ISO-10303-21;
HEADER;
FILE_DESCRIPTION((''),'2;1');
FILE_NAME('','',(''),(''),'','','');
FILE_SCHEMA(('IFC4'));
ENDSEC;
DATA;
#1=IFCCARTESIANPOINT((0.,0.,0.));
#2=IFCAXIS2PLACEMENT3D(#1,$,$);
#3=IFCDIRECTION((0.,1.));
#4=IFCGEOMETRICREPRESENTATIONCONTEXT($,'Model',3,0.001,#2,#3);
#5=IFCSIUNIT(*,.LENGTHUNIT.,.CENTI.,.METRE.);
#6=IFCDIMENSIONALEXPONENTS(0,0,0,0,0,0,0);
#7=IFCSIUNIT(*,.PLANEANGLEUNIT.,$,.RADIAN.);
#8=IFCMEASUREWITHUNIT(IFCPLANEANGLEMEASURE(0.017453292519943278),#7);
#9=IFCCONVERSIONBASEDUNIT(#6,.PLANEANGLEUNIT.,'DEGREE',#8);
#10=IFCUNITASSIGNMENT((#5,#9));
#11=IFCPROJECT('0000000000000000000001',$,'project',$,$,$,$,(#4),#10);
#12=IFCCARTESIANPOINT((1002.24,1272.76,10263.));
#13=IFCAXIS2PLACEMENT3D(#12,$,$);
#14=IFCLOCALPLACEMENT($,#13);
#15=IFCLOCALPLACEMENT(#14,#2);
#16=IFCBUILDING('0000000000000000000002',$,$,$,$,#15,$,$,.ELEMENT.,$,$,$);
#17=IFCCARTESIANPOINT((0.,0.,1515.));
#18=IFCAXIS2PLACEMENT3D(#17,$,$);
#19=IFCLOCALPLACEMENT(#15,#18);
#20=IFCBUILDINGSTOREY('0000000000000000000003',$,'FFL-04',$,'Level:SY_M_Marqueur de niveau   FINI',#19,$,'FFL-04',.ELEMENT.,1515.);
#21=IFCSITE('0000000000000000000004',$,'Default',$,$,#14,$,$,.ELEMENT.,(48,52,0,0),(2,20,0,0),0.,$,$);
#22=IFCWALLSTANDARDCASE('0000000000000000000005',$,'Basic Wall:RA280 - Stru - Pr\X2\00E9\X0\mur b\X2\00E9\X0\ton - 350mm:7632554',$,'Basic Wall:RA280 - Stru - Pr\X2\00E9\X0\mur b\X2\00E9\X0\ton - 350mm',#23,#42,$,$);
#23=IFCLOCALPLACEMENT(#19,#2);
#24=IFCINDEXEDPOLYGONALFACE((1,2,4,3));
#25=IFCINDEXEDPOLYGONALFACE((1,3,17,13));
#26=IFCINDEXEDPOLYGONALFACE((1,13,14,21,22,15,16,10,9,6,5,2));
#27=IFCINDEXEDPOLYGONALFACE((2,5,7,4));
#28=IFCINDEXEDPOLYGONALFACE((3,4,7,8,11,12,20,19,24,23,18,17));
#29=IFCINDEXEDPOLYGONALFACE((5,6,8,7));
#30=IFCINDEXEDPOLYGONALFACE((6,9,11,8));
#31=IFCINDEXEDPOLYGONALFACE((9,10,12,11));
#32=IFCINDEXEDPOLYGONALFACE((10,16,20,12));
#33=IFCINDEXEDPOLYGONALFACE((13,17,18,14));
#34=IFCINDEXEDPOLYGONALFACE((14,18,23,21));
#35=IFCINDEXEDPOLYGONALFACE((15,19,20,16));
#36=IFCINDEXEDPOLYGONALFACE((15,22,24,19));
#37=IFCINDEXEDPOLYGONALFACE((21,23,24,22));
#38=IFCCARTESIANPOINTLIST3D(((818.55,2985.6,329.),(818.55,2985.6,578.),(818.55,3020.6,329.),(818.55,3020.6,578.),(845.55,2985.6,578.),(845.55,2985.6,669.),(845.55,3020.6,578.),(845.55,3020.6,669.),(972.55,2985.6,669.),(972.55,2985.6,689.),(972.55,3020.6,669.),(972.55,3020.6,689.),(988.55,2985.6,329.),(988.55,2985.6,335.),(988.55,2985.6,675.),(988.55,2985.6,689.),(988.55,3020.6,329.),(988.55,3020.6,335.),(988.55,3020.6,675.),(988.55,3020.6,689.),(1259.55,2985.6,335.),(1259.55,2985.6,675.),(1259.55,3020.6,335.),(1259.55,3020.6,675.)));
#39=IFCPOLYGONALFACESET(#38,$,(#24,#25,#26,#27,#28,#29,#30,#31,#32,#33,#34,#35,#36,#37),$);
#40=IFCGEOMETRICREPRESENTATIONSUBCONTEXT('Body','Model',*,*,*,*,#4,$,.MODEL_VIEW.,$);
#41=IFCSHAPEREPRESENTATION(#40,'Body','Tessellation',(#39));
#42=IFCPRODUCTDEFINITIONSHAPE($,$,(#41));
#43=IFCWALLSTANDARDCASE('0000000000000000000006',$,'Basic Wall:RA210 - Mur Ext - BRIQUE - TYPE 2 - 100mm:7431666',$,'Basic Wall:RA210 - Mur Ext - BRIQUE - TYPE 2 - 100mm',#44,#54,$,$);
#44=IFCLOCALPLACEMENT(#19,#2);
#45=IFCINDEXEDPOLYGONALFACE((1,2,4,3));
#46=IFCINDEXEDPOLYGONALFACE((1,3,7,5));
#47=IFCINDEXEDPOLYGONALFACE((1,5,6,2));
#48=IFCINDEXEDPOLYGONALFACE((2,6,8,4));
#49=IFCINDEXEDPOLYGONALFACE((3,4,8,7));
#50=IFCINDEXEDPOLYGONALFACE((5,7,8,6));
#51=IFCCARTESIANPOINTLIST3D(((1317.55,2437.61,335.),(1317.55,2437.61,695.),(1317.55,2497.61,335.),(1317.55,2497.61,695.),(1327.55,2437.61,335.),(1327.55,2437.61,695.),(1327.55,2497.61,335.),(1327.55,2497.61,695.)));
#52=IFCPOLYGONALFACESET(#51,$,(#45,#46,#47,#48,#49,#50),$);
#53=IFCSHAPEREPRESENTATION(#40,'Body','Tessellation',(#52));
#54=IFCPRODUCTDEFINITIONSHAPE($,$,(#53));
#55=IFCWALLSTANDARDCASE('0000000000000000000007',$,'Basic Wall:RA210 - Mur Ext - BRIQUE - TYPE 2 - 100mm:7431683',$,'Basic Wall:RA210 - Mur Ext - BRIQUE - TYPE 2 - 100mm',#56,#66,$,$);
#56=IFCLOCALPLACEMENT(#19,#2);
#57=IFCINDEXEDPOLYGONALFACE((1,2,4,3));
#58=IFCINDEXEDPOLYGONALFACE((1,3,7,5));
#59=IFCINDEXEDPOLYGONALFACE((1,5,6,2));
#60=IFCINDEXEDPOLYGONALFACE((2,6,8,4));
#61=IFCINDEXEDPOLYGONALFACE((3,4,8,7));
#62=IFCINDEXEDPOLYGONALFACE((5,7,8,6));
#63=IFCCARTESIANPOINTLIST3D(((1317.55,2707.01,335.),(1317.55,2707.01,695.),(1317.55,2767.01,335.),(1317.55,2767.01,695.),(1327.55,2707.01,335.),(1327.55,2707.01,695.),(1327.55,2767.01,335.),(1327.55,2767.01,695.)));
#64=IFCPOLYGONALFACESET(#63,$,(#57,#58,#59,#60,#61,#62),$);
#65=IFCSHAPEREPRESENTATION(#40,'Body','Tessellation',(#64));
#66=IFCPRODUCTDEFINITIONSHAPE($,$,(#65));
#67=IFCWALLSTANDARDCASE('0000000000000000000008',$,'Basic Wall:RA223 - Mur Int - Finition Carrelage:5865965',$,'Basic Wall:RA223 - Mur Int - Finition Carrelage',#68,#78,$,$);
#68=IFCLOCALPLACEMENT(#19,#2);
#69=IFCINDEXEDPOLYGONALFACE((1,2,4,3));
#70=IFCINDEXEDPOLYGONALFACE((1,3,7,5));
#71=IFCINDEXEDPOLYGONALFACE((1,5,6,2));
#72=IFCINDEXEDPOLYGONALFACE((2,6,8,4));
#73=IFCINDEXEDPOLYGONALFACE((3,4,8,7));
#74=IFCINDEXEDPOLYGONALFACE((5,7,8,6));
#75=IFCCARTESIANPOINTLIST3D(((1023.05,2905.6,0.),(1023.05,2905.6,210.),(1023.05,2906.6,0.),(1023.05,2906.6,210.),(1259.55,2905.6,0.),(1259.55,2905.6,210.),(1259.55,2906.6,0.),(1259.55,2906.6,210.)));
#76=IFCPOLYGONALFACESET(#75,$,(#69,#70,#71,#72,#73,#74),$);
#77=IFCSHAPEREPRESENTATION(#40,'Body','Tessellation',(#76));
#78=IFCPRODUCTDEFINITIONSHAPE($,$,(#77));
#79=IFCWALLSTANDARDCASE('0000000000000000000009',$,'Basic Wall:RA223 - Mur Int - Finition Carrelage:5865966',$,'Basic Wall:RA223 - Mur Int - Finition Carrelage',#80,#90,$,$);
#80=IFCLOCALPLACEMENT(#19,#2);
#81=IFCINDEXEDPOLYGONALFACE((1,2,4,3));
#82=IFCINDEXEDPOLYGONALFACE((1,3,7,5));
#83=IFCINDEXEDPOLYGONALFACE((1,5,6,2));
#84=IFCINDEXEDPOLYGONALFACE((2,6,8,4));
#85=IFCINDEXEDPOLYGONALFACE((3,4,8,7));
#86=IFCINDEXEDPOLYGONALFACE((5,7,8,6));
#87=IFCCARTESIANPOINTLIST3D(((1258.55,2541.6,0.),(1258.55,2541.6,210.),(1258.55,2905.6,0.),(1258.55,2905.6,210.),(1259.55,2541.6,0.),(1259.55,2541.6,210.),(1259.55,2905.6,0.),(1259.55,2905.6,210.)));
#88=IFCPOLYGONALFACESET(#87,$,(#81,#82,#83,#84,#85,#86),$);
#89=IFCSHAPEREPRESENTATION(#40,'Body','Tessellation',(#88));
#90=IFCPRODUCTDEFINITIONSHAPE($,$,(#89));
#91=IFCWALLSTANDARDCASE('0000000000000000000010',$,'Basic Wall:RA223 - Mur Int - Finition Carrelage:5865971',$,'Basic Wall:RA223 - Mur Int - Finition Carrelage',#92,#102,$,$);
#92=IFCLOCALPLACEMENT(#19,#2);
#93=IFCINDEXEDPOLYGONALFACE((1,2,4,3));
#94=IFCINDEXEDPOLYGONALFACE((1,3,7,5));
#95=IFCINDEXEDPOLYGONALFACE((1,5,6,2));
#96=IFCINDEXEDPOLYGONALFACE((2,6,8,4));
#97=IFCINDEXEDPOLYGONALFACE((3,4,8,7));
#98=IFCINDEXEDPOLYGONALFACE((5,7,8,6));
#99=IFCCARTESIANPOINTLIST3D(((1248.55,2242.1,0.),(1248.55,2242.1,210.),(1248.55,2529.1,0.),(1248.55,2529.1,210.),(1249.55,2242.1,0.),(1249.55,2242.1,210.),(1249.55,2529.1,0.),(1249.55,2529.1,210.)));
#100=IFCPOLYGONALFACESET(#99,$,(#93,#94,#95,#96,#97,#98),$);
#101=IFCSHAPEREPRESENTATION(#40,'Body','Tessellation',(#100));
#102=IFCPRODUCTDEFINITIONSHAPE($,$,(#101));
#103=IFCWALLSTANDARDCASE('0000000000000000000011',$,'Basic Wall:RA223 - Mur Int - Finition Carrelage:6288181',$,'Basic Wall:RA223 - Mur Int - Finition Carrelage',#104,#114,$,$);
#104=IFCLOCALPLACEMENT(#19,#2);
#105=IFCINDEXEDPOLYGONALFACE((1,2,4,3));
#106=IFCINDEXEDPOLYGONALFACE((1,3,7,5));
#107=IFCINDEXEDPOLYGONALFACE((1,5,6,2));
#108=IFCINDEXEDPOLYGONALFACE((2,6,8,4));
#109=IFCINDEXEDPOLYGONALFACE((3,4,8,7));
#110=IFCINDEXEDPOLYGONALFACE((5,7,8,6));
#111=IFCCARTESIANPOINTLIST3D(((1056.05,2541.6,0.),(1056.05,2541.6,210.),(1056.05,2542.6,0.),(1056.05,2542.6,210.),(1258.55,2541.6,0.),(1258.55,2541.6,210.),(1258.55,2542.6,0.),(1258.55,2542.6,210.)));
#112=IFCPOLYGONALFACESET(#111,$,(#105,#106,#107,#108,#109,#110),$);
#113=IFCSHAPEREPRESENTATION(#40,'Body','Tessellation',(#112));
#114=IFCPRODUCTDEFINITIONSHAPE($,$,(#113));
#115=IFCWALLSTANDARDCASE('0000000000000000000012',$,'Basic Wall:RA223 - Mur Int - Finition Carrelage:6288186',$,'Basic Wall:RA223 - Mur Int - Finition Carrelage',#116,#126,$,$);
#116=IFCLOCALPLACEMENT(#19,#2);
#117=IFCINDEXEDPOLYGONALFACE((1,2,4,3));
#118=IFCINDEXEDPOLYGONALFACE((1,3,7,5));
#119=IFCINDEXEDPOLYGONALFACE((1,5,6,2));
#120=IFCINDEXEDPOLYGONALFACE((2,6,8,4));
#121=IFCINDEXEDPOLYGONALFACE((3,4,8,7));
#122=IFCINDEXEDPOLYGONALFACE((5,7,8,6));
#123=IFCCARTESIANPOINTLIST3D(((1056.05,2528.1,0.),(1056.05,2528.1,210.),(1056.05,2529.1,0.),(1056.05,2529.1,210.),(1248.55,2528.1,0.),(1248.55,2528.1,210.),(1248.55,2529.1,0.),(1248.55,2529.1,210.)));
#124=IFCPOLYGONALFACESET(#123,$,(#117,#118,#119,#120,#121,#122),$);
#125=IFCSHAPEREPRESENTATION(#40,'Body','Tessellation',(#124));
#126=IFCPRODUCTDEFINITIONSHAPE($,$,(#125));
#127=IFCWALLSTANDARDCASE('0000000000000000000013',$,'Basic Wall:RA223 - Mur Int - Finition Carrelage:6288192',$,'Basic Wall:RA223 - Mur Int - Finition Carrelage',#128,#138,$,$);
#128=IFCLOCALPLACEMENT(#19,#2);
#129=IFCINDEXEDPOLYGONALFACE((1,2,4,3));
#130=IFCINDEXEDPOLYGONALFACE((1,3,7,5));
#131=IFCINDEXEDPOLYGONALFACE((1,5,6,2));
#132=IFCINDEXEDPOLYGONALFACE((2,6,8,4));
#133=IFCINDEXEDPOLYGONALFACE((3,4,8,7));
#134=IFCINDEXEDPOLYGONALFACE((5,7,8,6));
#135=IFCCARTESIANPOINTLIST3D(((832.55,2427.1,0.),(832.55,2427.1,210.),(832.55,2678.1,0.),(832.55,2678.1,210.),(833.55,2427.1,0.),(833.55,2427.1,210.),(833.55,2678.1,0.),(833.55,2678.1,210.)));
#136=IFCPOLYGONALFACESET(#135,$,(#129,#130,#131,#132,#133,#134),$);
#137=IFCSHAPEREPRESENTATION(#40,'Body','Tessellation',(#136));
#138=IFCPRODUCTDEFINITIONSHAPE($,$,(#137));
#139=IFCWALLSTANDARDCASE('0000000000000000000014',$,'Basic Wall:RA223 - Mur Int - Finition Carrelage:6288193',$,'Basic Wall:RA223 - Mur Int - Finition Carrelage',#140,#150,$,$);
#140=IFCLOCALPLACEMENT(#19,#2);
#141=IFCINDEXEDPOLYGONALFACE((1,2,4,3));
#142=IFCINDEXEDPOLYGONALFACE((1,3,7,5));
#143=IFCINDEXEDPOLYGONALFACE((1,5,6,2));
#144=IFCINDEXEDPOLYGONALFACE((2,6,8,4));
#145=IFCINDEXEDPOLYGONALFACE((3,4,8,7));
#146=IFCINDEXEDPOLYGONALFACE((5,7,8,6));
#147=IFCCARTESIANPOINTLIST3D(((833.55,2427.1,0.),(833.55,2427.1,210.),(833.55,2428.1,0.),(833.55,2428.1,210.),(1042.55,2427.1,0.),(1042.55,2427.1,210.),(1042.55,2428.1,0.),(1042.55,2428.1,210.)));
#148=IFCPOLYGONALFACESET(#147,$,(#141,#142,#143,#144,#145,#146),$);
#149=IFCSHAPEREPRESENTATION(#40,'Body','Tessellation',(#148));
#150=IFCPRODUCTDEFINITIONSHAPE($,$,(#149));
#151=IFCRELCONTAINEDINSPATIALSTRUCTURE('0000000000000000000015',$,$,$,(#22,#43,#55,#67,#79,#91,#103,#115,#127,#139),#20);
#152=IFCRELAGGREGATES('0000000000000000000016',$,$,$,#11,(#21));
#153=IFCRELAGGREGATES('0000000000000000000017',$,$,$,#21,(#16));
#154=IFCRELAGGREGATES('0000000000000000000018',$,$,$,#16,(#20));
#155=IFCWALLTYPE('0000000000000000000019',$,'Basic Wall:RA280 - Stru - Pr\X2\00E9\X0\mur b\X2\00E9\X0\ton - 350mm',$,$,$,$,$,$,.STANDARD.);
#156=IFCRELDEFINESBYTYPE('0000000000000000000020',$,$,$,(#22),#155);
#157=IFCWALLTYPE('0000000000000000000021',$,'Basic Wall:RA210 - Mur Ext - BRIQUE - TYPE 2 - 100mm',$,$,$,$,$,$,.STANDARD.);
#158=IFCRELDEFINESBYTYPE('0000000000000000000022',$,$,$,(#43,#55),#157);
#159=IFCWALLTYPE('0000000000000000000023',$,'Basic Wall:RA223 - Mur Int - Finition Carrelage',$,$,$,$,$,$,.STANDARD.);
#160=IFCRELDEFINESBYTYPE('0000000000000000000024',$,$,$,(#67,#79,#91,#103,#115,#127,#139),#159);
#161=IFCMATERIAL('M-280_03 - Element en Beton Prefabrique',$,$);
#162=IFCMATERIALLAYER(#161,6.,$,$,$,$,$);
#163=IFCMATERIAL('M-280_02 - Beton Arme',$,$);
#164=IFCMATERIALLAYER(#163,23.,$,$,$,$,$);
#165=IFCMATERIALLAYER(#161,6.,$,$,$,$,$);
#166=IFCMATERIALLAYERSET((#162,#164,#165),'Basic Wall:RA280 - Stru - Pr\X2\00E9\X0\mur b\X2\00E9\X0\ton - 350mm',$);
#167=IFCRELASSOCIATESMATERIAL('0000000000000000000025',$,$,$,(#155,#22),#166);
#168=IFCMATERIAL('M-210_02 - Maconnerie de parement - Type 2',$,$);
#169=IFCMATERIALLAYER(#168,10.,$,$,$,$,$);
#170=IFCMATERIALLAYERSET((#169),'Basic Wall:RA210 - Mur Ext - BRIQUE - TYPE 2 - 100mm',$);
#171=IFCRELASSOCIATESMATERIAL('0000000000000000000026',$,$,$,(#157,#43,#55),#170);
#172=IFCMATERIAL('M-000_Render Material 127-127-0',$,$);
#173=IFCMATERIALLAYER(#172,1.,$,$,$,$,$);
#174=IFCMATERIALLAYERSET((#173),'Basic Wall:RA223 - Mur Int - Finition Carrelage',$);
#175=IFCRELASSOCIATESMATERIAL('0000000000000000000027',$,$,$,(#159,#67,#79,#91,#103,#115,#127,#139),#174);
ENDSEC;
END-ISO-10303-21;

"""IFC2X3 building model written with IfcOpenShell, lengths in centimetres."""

from ifc_helpers import new_model, entity, si_unit, converted_unit, direction, frame, frame_2d, origin, place, context, subcontext, project, spatial, polyline, rectangle, extrude, clip, bounded_halfspace, material, layer, layer_set, layer_usage, type_object, element, save


model = new_model("IFC2X3")

# Units and contexts
model_context = context("Model", 3, precision=0.001, world=origin(), true_north=direction((0.0, 1.0)))
body_context = subcontext(model_context, "Body", "Model", "MODEL_VIEW")
ifc_project = project(units=[si_unit("LENGTHUNIT", "METRE", prefix="CENTI"), converted_unit("PLANEANGLEUNIT", "DEGREE", entity("IfcPlaneAngleMeasure", 0.017453292519943278), si_unit("PLANEANGLEUNIT", "RADIAN"), dimensions=[0, 0, 0, 0, 0, 0, 0])], contexts=[model_context])

# Site, building, storey
site_placement = place(None, frame((1002.24, 1272.76, 10263.0)))
site = spatial("IfcSite", under=ifc_project, at=site_placement, Name="Default", CompositionType="ELEMENT", RefLatitude=(48, 52, 0, 0), RefLongitude=(2, 20, 0, 0), RefElevation=0.0)
building_placement = place(site_placement, origin())
building = spatial("IfcBuilding", under=site, at=building_placement, CompositionType="ELEMENT")
storey_placement = place(building_placement, frame((0.0, 0.0, 1515.0)))
storey = spatial("IfcBuildingStorey", under=building, at=storey_placement, Name="FFL-04", ObjectType="Level:SY_M_Marqueur de niveau   FINI", LongName="FFL-04", CompositionType="ELEMENT", Elevation=1515.0)

# Shared definitions
ifc_material_1 = material(Name="M-280_02 - Beton Arme")

# Walls
ifc_material_2 = material(Name="M-210_02 - Maconnerie de parement - Type 2")
ifc_material_3 = material(Name="M-280_03 - Element en Beton Prefabrique")
ifc_layer_1 = layer(ifc_material_3, 6.0)
ifc_layer_2 = layer(ifc_material_1, 23.0)
ifc_layer_3 = layer(ifc_material_3, 6.0)
ifc_layer_set_1 = layer_set([ifc_layer_1, ifc_layer_2, ifc_layer_3], Name="Basic Wall:RA280 - Stru - Prémur béton - 350mm")
ifc_layer_usage_1 = layer_usage(ifc_layer_set_1, "AXIS2", "NEGATIVE", 17.5)
wall_type_1 = type_object("IfcWallType", Name="Basic Wall:RA280 - Stru - Prémur béton - 350mm", PredefinedType="STANDARD", material=ifc_layer_set_1)
wall_1_placement = place(storey_placement, frame((818.55, 3003.1, 329.0)))
element("IfcWallStandardCase", 1, at=wall_1_placement, inside=storey, type_object=wall_type_1, material=ifc_layer_usage_1, Name="Basic Wall:RA280 - Stru - Prémur béton - 350mm:7632554", ObjectType="Basic Wall:RA280 - Stru - Prémur béton - 350mm", context=body_context, shape_type="Clipping", body=[
    clip(clip(clip(clip(clip(clip(clip(clip(extrude(rectangle(XDim=440.99, YDim=35.0, at=frame_2d((220.5, 0.0), x_axis=(-1.0, 0.0))), origin(), (0.0, 0.0, 1.0), 360.0), bounded_halfspace(frame((27.0, -17.5, 340.0), z_axis=(1.0, 0.0, 0.0), x_axis=(0.0, 0.0, 1.0)), True, frame((27.0, -17.5, 340.0), z_axis=(1.0, 0.0, 0.0), x_axis=(0.0, 0.0, 1.0)), polyline([(0.0, 0.0), (-6.0, 0.0), (-91.0, 0.0), (-91.0, -35.0), (0.0, -35.0), (0.0, 0.0)]))), bounded_halfspace(frame((169.99, 17.5, 346.0), z_axis=(0.0, 0.0, -1.0), x_axis=(-1.0, 0.0, 0.0)), True, frame((169.99, 17.5, 346.0), z_axis=(0.0, 0.0, -1.0), x_axis=(-1.0, 0.0, 0.0)), polyline([(0.0, 0.0), (-271.0, 0.0), (-271.0, -35.0), (-256.25, -35.0), (-250.0, -35.0), (-66.51, -35.0), (-54.01, -35.0), (-25.0, -35.0), (0.0, -35.0), (0.0, 0.0)]))), bounded_halfspace(frame((169.99, -17.5, 346.0), z_axis=(-1.0, 0.0, 0.0), x_axis=(0.0, 0.0, 1.0)), True, frame((169.99, -17.5, 346.0), z_axis=(-1.0, 0.0, 0.0), x_axis=(0.0, 0.0, 1.0)), polyline([(0.0, 0.0), (14.0, 0.0), (14.0, 35.0), (0.0, 35.0), (0.0, 0.0)]))), bounded_halfspace(frame((153.99, -17.5, 340.0), z_axis=(0.0, 0.0, -1.0), x_axis=(1.0, 0.0, 0.0)), True, frame((153.99, -17.5, 340.0), z_axis=(0.0, 0.0, -1.0), x_axis=(1.0, 0.0, 0.0)), polyline([(0.0, 0.0), (-126.99, 0.0), (-126.99, -35.0), (0.0, -35.0), (0.0, 0.0)]))), bounded_halfspace(frame((153.99, 17.5, 340.0), z_axis=(1.0, 0.0, 0.0), x_axis=(0.0, 0.0, 1.0)), True, frame((153.99, 17.5, 340.0), z_axis=(1.0, 0.0, 0.0), x_axis=(0.0, 0.0, 1.0)), polyline([(0.0, 0.0), (20.0, 0.0), (20.0, 35.0), (0.0, 35.0), (0.0, 0.0)]))), bounded_halfspace(frame((169.99, -17.5, 6.0)), True, frame((169.99, -17.5, 6.0)), polyline([(0.0, 0.0), (271.0, 0.0), (271.0, 35.0), (0.0, 35.0), (0.0, 0.0)]))), bounded_halfspace(frame((169.99, 17.5, 6.0), z_axis=(-1.0, 0.0, 0.0), x_axis=(0.0, 0.0, 1.0)), True, frame((169.99, 17.5, 6.0), z_axis=(-1.0, 0.0, 0.0), x_axis=(0.0, 0.0, 1.0)), polyline([(0.0, 0.0), (-6.0, 0.0), (-6.0, -35.0), (0.0, -35.0), (0.0, 0.0)]))), bounded_halfspace(frame((27.0, -17.5, 249.0)), False, frame((27.0, -17.5, 249.0)), polyline([(0.0, 0.0), (0.0, 35.0), (-27.0, 35.0), (-27.0, 0.0), (0.0, 0.0)]))),
])
ifc_layer_4 = layer(ifc_material_2, 10.0)
ifc_layer_set_2 = layer_set([ifc_layer_4], Name="Basic Wall:RA210 - Mur Ext - BRIQUE - TYPE 2 - 100mm")
ifc_layer_usage_2 = layer_usage(ifc_layer_set_2, "AXIS2", "POSITIVE", -5.0)
wall_type_2 = type_object("IfcWallType", Name="Basic Wall:RA210 - Mur Ext - BRIQUE - TYPE 2 - 100mm", PredefinedType="STANDARD", material=ifc_layer_set_2)
wall_2_placement = place(storey_placement, frame((1322.55, 2437.61, 335.0), z_axis=(0.0, 0.0, 1.0), x_axis=(0.0, 1.0, 0.0)))
element("IfcWallStandardCase", 2, at=wall_2_placement, inside=storey, type_object=wall_type_2, material=ifc_layer_usage_2, Name="Basic Wall:RA210 - Mur Ext - BRIQUE - TYPE 2 - 100mm:7431666", ObjectType="Basic Wall:RA210 - Mur Ext - BRIQUE - TYPE 2 - 100mm", context=body_context, shape_type="SweptSolid", body=[
    extrude(rectangle(XDim=60.0, YDim=10.0, at=frame_2d((30.0, 0.0), x_axis=(-1.0, 0.0))), origin(), (0.0, 0.0, 1.0), 360.0),
])
ifc_layer_usage_3 = layer_usage(ifc_layer_set_2, "AXIS2", "POSITIVE", -5.0)
wall_3_placement = place(storey_placement, frame((1322.55, 2707.01, 335.0), z_axis=(0.0, 0.0, 1.0), x_axis=(0.0, 1.0, 0.0)))
element("IfcWallStandardCase", 3, at=wall_3_placement, inside=storey, type_object=wall_type_2, material=ifc_layer_usage_3, Name="Basic Wall:RA210 - Mur Ext - BRIQUE - TYPE 2 - 100mm:7431683", ObjectType="Basic Wall:RA210 - Mur Ext - BRIQUE - TYPE 2 - 100mm", context=body_context, shape_type="SweptSolid", body=[
    extrude(rectangle(XDim=60.0, YDim=10.0, at=frame_2d((30.0, 0.0), x_axis=(-1.0, 0.0))), origin(), (0.0, 0.0, 1.0), 360.0),
])
ifc_material_4 = material(Name="M-000_Render Material 127-127-0")
ifc_layer_5 = layer(ifc_material_4, 1.0)
ifc_layer_set_3 = layer_set([ifc_layer_5], Name="Basic Wall:RA223 - Mur Int - Finition Carrelage")
ifc_layer_usage_4 = layer_usage(ifc_layer_set_3, "AXIS2", "POSITIVE", -0.5)
wall_type_3 = type_object("IfcWallType", Name="Basic Wall:RA223 - Mur Int - Finition Carrelage", PredefinedType="STANDARD", material=ifc_layer_set_3)
wall_4_placement = place(storey_placement, frame((1023.05, 2906.1, 0.0)))
element("IfcWallStandardCase", 4, at=wall_4_placement, inside=storey, type_object=wall_type_3, material=ifc_layer_usage_4, Name="Basic Wall:RA223 - Mur Int - Finition Carrelage:5865965", ObjectType="Basic Wall:RA223 - Mur Int - Finition Carrelage", context=body_context, shape_type="SweptSolid", body=[
    extrude(rectangle(XDim=236.49, YDim=1.0, at=frame_2d((118.25, 0.0), x_axis=(-1.0, 0.0))), origin(), (0.0, 0.0, 1.0), 210.0),
])
ifc_layer_usage_5 = layer_usage(ifc_layer_set_3, "AXIS2", "NEGATIVE", 0.5)
wall_5_placement = place(storey_placement, frame((1259.05, 2541.6, 0.0), z_axis=(0.0, 0.0, 1.0), x_axis=(0.0, 1.0, 0.0)))
element("IfcWallStandardCase", 5, at=wall_5_placement, inside=storey, type_object=wall_type_3, material=ifc_layer_usage_5, Name="Basic Wall:RA223 - Mur Int - Finition Carrelage:5865966", ObjectType="Basic Wall:RA223 - Mur Int - Finition Carrelage", context=body_context, shape_type="SweptSolid", body=[
    extrude(rectangle(XDim=364.0, YDim=1.0, at=frame_2d((182.0, 0.0), x_axis=(-1.0, 0.0))), origin(), (0.0, 0.0, 1.0), 210.0),
])
ifc_layer_usage_6 = layer_usage(ifc_layer_set_3, "AXIS2", "POSITIVE", -0.5)
wall_6_placement = place(storey_placement, frame((1249.05, 2529.1, 0.0), z_axis=(0.0, 0.0, 1.0), x_axis=(0.0, -1.0, 0.0)))
element("IfcWallStandardCase", 6, at=wall_6_placement, inside=storey, type_object=wall_type_3, material=ifc_layer_usage_6, Name="Basic Wall:RA223 - Mur Int - Finition Carrelage:5865971", ObjectType="Basic Wall:RA223 - Mur Int - Finition Carrelage", context=body_context, shape_type="SweptSolid", body=[
    extrude(rectangle(XDim=287.0, YDim=1.0, at=frame_2d((143.5, 0.0), x_axis=(-1.0, 0.0))), origin(), (0.0, 0.0, 1.0), 210.0),
])

# Walls
ifc_layer_usage_7 = layer_usage(ifc_layer_set_3, "AXIS2", "POSITIVE", -0.5)
wall_7_placement = place(storey_placement, frame((1258.55, 2542.1, 0.0), z_axis=(0.0, 0.0, 1.0), x_axis=(-1.0, 0.0, 0.0)))
element("IfcWallStandardCase", 7, at=wall_7_placement, inside=storey, type_object=wall_type_3, material=ifc_layer_usage_7, Name="Basic Wall:RA223 - Mur Int - Finition Carrelage:6288181", ObjectType="Basic Wall:RA223 - Mur Int - Finition Carrelage", context=body_context, shape_type="SweptSolid", body=[
    extrude(rectangle(XDim=202.49, YDim=1.0, at=frame_2d((101.25, 0.0), x_axis=(-1.0, 0.0))), origin(), (0.0, 0.0, 1.0), 210.0),
])
ifc_layer_usage_8 = layer_usage(ifc_layer_set_3, "AXIS2", "POSITIVE", -0.5)
wall_8_placement = place(storey_placement, frame((1056.05, 2528.6, 0.0)))
element("IfcWallStandardCase", 8, at=wall_8_placement, inside=storey, type_object=wall_type_3, material=ifc_layer_usage_8, Name="Basic Wall:RA223 - Mur Int - Finition Carrelage:6288186", ObjectType="Basic Wall:RA223 - Mur Int - Finition Carrelage", context=body_context, shape_type="SweptSolid", body=[
    extrude(rectangle(XDim=192.49, YDim=1.0, at=frame_2d((96.25, 0.0), x_axis=(-1.0, 0.0))), origin(), (0.0, 0.0, 1.0), 210.0),
])

# Walls
ifc_layer_usage_9 = layer_usage(ifc_layer_set_3, "AXIS2", "POSITIVE", -0.5)
wall_9_placement = place(storey_placement, frame((833.05, 2427.1, 0.0), z_axis=(0.0, 0.0, 1.0), x_axis=(0.0, 1.0, 0.0)))
element("IfcWallStandardCase", 9, at=wall_9_placement, inside=storey, type_object=wall_type_3, material=ifc_layer_usage_9, Name="Basic Wall:RA223 - Mur Int - Finition Carrelage:6288192", ObjectType="Basic Wall:RA223 - Mur Int - Finition Carrelage", context=body_context, shape_type="SweptSolid", body=[
    extrude(rectangle(XDim=251.0, YDim=1.0, at=frame_2d((125.5, 0.0), x_axis=(-1.0, 0.0))), origin(), (0.0, 0.0, 1.0), 210.0),
])
ifc_layer_usage_10 = layer_usage(ifc_layer_set_3, "AXIS2", "POSITIVE", -0.5)
wall_10_placement = place(storey_placement, frame((1042.55, 2427.6, 0.0), z_axis=(0.0, 0.0, 1.0), x_axis=(-1.0, 0.0, 0.0)))
element("IfcWallStandardCase", 10, at=wall_10_placement, inside=storey, type_object=wall_type_3, material=ifc_layer_usage_10, Name="Basic Wall:RA223 - Mur Int - Finition Carrelage:6288193", ObjectType="Basic Wall:RA223 - Mur Int - Finition Carrelage", context=body_context, shape_type="SweptSolid", body=[
    extrude(rectangle(XDim=209.0, YDim=1.0, at=frame_2d((104.5, 0.0), x_axis=(-1.0, 0.0))), origin(), (0.0, 0.0, 1.0), 210.0),
])

save(model, "model.ifc")
